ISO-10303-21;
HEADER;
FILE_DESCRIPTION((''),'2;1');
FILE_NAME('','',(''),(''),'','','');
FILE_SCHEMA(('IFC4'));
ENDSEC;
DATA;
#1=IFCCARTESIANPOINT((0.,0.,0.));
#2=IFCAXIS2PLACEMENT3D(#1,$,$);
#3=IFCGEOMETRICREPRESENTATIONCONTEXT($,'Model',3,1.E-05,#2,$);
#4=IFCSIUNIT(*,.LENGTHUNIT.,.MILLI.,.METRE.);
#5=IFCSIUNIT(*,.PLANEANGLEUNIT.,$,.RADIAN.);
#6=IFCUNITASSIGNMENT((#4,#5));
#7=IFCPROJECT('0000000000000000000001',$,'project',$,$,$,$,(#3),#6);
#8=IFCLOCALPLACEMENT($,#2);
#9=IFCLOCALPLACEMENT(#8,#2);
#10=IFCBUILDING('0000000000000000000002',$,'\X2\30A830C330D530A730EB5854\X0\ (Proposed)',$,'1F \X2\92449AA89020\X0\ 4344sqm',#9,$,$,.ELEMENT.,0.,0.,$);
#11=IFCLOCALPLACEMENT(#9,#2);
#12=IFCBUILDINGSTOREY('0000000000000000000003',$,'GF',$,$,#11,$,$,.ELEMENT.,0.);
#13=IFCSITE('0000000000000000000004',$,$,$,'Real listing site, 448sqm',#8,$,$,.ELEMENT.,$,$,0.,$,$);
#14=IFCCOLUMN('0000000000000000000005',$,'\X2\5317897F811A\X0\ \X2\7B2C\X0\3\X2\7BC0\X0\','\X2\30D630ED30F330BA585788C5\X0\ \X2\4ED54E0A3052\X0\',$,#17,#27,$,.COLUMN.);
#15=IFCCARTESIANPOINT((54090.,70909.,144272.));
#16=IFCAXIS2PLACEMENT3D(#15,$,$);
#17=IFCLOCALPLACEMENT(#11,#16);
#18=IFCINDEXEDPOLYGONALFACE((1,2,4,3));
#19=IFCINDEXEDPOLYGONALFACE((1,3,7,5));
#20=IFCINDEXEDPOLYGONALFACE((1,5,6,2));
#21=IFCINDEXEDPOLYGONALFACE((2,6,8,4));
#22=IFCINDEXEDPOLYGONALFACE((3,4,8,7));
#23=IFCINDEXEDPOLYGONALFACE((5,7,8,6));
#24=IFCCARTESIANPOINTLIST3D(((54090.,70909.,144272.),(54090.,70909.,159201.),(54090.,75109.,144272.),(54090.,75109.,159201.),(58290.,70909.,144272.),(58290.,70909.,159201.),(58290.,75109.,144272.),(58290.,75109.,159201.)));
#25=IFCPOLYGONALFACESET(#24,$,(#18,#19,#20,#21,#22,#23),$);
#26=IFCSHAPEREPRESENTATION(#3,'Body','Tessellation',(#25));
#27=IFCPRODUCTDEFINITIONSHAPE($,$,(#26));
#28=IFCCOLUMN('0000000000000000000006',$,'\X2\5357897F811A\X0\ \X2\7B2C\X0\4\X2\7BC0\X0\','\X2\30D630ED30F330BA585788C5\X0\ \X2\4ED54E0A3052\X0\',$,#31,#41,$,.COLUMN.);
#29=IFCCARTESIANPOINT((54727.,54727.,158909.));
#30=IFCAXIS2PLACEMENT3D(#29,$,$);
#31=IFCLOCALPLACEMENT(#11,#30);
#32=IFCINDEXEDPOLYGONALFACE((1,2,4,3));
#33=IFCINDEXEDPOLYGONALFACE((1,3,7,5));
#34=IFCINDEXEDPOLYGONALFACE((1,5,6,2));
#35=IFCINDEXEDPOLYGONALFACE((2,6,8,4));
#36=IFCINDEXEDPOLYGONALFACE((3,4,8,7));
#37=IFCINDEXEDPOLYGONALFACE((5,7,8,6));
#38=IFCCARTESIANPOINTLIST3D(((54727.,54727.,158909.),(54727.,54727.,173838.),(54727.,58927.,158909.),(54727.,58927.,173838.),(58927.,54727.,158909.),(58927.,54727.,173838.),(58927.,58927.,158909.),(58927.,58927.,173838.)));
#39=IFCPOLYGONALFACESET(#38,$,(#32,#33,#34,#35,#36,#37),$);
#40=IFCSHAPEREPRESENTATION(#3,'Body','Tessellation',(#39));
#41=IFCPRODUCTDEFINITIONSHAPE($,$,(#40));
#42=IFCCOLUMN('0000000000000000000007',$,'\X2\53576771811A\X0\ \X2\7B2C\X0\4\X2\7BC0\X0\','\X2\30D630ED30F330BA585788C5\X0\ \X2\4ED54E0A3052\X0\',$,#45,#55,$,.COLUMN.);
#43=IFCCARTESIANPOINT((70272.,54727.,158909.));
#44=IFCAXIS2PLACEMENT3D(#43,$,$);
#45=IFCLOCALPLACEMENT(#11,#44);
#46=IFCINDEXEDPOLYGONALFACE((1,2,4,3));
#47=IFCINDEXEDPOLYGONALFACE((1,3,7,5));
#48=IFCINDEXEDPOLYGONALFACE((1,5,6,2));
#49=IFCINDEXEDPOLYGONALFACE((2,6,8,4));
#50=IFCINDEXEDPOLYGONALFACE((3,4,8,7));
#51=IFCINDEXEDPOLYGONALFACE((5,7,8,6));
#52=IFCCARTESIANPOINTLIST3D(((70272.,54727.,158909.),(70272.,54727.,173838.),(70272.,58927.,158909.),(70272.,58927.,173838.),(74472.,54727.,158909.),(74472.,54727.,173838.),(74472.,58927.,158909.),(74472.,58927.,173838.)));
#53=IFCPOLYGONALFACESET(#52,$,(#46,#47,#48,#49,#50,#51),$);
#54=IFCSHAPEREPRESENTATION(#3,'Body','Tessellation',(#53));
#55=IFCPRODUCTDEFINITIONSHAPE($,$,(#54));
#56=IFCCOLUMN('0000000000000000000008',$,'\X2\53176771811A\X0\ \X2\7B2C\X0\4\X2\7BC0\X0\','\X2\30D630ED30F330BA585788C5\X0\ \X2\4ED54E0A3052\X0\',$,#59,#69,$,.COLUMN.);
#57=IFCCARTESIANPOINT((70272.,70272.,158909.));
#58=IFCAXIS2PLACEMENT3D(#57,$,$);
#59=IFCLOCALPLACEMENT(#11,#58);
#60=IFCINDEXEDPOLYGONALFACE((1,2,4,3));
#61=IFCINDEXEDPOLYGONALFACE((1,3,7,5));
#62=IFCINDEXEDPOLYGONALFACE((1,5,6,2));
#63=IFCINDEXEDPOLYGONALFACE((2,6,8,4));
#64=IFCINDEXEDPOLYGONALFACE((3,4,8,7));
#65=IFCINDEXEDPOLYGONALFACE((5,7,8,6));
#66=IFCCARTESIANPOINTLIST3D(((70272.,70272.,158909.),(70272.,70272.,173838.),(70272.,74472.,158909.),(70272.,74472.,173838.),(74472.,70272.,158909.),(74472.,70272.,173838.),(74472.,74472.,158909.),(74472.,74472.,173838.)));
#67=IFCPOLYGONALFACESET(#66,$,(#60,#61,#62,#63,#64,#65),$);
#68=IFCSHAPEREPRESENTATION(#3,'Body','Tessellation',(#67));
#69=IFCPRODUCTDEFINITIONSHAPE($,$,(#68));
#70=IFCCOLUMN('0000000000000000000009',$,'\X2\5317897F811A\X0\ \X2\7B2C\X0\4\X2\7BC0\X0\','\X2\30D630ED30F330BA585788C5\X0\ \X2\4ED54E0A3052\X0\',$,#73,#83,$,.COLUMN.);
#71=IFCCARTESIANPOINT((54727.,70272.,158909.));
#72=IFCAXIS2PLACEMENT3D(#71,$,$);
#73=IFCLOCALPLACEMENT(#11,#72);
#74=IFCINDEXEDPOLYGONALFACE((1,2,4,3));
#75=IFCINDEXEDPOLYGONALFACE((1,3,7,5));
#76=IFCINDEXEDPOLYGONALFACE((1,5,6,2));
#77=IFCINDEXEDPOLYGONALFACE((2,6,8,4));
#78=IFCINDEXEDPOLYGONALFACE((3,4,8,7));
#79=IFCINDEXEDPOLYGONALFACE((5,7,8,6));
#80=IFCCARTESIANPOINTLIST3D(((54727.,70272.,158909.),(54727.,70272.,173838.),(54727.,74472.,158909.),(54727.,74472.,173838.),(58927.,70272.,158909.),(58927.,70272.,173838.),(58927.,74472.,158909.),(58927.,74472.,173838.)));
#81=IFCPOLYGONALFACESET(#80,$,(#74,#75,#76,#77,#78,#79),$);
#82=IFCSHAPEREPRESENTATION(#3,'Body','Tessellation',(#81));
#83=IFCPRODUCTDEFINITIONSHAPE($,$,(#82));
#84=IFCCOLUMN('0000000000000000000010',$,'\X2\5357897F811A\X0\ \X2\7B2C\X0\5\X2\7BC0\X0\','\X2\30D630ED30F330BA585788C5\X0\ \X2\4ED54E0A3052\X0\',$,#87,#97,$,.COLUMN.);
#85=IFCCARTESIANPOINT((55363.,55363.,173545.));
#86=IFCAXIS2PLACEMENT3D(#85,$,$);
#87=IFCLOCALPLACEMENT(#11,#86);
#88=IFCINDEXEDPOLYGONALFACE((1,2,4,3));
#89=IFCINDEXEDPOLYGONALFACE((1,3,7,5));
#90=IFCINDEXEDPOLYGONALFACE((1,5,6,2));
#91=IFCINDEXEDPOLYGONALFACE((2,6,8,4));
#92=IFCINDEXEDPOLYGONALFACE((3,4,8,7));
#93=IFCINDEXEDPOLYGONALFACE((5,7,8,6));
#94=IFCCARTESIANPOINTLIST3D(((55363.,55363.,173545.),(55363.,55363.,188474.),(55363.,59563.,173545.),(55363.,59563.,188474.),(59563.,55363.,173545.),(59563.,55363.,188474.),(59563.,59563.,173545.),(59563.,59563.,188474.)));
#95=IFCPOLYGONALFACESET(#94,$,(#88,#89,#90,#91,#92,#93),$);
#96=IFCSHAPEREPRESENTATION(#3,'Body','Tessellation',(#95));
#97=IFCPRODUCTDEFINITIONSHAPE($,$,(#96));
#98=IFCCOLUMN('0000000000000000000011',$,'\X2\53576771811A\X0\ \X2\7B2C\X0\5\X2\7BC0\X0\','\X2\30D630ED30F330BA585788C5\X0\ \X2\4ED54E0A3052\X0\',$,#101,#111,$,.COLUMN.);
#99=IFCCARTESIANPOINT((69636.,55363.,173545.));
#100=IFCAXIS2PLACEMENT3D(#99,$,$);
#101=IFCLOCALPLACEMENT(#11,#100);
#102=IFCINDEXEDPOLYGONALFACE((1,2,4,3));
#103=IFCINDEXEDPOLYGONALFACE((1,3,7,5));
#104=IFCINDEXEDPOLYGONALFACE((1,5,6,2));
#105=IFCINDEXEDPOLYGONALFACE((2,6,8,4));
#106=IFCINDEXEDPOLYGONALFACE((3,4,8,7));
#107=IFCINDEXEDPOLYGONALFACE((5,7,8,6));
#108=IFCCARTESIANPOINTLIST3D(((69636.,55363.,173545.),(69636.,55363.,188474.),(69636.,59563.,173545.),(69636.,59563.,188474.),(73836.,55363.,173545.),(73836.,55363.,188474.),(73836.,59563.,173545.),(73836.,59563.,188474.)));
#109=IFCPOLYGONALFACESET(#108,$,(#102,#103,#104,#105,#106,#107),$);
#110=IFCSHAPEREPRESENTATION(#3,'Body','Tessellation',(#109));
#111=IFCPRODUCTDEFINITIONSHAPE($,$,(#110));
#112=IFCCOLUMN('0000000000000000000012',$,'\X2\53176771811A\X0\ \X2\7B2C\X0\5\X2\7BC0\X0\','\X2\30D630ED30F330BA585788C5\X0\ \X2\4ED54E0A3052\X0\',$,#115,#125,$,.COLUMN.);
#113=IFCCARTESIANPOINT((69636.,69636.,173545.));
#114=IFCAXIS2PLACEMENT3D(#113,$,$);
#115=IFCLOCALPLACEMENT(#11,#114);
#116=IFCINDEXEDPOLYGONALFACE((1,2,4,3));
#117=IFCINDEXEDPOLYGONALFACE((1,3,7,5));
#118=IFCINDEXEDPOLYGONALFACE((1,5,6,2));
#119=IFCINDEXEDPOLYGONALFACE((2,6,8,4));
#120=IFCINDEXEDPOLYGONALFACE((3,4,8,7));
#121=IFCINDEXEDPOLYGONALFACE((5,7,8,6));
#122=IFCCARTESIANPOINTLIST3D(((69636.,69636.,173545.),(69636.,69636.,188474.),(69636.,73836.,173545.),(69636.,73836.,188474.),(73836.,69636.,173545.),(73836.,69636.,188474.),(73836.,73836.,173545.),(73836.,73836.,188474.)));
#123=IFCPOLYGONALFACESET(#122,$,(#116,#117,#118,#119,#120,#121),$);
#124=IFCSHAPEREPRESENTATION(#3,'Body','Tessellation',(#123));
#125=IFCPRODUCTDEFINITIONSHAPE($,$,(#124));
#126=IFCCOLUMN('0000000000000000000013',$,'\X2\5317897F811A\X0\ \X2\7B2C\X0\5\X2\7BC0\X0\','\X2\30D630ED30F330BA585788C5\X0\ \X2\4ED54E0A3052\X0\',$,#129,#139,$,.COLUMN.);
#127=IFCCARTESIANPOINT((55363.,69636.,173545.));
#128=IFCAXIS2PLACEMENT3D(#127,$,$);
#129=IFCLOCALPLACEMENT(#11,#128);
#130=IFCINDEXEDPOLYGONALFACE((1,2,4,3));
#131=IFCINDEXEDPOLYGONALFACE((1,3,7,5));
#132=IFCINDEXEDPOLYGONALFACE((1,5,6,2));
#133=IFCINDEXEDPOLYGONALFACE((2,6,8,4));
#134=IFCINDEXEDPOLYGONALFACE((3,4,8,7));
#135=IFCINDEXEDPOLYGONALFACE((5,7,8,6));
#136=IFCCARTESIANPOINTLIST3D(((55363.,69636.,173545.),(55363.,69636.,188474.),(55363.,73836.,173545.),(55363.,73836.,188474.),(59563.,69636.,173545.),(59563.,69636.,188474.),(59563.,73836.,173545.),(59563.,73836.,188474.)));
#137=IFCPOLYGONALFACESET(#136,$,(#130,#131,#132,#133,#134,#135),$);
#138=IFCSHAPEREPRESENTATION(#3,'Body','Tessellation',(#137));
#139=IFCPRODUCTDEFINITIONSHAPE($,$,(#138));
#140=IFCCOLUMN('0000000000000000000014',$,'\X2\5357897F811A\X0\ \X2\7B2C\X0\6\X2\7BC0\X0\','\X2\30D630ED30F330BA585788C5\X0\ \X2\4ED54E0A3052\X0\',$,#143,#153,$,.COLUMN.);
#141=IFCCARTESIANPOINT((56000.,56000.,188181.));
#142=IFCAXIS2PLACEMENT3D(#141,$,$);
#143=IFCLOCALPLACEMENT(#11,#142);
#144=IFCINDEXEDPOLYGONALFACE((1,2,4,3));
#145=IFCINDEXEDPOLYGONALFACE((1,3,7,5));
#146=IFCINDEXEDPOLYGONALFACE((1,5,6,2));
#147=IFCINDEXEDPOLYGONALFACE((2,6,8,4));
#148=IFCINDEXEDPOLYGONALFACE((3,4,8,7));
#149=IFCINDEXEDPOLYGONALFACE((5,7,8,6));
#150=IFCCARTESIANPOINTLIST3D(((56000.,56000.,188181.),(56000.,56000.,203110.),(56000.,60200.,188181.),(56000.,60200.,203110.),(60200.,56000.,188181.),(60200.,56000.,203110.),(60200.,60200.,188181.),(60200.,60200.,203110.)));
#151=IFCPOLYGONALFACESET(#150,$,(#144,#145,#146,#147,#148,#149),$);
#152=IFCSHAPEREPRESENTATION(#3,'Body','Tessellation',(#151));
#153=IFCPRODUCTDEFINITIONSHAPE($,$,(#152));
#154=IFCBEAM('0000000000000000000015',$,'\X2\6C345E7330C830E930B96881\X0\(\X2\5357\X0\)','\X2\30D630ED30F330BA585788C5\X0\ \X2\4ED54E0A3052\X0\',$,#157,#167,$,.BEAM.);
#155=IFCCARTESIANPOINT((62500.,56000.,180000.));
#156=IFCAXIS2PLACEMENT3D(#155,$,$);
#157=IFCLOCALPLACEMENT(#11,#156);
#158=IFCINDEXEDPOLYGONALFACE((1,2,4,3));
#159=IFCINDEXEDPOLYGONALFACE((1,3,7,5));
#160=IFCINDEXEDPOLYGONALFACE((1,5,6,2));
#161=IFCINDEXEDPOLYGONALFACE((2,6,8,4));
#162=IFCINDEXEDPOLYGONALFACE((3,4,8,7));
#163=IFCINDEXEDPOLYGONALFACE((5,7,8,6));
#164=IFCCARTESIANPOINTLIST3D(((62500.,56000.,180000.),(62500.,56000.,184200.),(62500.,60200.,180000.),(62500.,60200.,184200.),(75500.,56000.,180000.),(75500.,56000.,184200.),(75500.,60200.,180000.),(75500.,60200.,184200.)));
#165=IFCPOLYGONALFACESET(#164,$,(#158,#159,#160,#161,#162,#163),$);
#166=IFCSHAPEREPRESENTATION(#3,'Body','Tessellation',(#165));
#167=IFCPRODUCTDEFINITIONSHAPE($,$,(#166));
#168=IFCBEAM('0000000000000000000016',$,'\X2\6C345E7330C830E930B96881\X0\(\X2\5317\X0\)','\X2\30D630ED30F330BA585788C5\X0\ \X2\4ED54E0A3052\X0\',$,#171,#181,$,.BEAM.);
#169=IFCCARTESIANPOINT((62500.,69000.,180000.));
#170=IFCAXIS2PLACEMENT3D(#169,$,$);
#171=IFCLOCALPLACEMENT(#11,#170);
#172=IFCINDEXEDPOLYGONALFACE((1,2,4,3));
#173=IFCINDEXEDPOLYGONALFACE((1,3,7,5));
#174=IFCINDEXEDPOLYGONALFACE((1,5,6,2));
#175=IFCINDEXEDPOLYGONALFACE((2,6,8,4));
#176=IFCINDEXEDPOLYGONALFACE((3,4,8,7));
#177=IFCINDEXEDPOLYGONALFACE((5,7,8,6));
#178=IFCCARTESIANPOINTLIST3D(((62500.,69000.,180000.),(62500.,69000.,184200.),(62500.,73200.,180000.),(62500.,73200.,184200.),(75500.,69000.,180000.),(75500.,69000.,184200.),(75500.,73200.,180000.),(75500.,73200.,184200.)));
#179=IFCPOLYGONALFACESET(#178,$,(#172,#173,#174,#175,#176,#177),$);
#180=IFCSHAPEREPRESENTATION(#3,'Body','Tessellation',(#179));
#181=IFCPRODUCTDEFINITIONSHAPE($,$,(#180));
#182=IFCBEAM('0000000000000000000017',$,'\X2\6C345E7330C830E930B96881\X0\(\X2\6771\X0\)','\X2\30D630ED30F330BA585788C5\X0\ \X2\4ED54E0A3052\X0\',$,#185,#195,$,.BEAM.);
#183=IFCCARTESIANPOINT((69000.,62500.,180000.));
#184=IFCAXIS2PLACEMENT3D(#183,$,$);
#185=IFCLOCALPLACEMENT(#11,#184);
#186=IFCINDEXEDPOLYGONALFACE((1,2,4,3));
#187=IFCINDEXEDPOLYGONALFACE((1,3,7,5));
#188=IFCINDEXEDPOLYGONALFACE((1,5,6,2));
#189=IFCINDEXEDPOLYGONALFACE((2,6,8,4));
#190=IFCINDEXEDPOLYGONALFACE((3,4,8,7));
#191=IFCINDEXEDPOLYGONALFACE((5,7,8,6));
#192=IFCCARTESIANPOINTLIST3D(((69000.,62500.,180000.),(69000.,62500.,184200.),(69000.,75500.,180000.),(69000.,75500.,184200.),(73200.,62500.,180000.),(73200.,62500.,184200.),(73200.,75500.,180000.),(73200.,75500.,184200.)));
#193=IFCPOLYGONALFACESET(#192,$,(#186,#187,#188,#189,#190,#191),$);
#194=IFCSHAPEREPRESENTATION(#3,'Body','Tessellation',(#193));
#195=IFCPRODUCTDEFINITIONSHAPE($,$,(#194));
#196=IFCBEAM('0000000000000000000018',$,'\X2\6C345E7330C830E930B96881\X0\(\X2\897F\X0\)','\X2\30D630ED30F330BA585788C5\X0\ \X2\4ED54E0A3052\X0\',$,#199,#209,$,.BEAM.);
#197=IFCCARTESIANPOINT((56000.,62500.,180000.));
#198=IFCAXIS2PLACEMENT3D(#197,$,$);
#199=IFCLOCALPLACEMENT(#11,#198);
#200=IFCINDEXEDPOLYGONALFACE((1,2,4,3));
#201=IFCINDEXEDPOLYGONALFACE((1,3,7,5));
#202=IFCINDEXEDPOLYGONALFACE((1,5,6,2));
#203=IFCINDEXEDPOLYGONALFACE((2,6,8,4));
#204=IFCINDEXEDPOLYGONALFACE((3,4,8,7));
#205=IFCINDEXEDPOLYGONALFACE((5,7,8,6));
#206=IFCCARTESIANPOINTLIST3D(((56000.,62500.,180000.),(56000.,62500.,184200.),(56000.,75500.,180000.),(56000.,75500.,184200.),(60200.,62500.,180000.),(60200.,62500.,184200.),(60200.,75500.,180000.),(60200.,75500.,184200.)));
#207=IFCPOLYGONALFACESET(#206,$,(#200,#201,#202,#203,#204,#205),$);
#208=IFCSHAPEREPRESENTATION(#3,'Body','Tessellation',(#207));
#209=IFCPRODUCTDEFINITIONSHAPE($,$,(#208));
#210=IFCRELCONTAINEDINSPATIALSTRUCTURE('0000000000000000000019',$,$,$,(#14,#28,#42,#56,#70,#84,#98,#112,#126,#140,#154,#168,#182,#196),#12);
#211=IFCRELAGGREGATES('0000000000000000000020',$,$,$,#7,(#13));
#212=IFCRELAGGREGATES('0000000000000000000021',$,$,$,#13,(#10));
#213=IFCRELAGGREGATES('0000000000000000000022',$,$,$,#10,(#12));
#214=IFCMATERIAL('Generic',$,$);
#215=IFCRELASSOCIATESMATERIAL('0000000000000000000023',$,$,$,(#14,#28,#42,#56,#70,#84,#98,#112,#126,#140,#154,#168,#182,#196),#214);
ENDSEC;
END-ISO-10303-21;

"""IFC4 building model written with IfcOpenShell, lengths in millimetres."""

from ifc_helpers import new_model, si_unit, frame, frame_2d, origin, place, context, project, spatial, rectangle, extrude, material, element, save


model = new_model("IFC4")

# Units and contexts
model_context = context("Model", 3, precision=1e-05, world=origin())
ifc_project = project(units=[si_unit("LENGTHUNIT", "METRE", prefix="MILLI"), si_unit("PLANEANGLEUNIT", "RADIAN")], contexts=[model_context])

# Site, building, storey
site_placement = place(None, origin())
site = spatial("IfcSite", under=ifc_project, at=site_placement, ObjectType="Real listing site, 448sqm", CompositionType="ELEMENT", RefElevation=0.0)
building_placement = place(site_placement, origin())
building = spatial("IfcBuilding", under=site, at=building_placement, Name="エッフェル塔 (Proposed)", ObjectType="1F 鉄骨造 4344sqm", CompositionType="ELEMENT", ElevationOfRefHeight=0.0, ElevationOfTerrain=0.0)
storey_placement = place(building_placement, origin())
storey = spatial("IfcBuildingStorey", under=building, at=storey_placement, Name="GF", CompositionType="ELEMENT", Elevation=0.0)

# Columns
ifc_material = material(Name="Generic")
column_1_placement = place(storey_placement, frame((54090.0, 70909.0, 144272.0)))
element("IfcColumn", 1, at=column_1_placement, inside=storey, material=ifc_material, Name="北西脚 第3節", Description="ブロンズ塗装 仕上げ", PredefinedType="COLUMN", context=model_context, shape_type="SweptSolid", body=[
    extrude(rectangle(XDim=4200.0, YDim=4200.0, at=frame_2d((2100.0, 2100.0))), frame((54090.0, 70909.0, 144272.0)), (0.0, 0.0, 1.0), 14929.0),
])
column_2_placement = place(storey_placement, frame((54727.0, 54727.0, 158909.0)))
element("IfcColumn", 2, at=column_2_placement, inside=storey, material=ifc_material, Name="南西脚 第4節", Description="ブロンズ塗装 仕上げ", PredefinedType="COLUMN", context=model_context, shape_type="SweptSolid", body=[
    extrude(rectangle(XDim=4200.0, YDim=4200.0, at=frame_2d((2100.0, 2100.0))), frame((54727.0, 54727.0, 158909.0)), (0.0, 0.0, 1.0), 14929.0),
])
column_3_placement = place(storey_placement, frame((70272.0, 54727.0, 158909.0)))
element("IfcColumn", 3, at=column_3_placement, inside=storey, material=ifc_material, Name="南東脚 第4節", Description="ブロンズ塗装 仕上げ", PredefinedType="COLUMN", context=model_context, shape_type="SweptSolid", body=[
    extrude(rectangle(XDim=4200.0, YDim=4200.0, at=frame_2d((2100.0, 2100.0))), frame((70272.0, 54727.0, 158909.0)), (0.0, 0.0, 1.0), 14929.0),
])
column_4_placement = place(storey_placement, frame((70272.0, 70272.0, 158909.0)))
element("IfcColumn", 4, at=column_4_placement, inside=storey, material=ifc_material, Name="北東脚 第4節", Description="ブロンズ塗装 仕上げ", PredefinedType="COLUMN", context=model_context, shape_type="SweptSolid", body=[
    extrude(rectangle(XDim=4200.0, YDim=4200.0, at=frame_2d((2100.0, 2100.0))), frame((70272.0, 70272.0, 158909.0)), (0.0, 0.0, 1.0), 14929.0),
])
column_5_placement = place(storey_placement, frame((54727.0, 70272.0, 158909.0)))
element("IfcColumn", 5, at=column_5_placement, inside=storey, material=ifc_material, Name="北西脚 第4節", Description="ブロンズ塗装 仕上げ", PredefinedType="COLUMN", context=model_context, shape_type="SweptSolid", body=[
    extrude(rectangle(XDim=4200.0, YDim=4200.0, at=frame_2d((2100.0, 2100.0))), frame((54727.0, 70272.0, 158909.0)), (0.0, 0.0, 1.0), 14929.0),
])
column_6_placement = place(storey_placement, frame((55363.0, 55363.0, 173545.0)))
element("IfcColumn", 6, at=column_6_placement, inside=storey, material=ifc_material, Name="南西脚 第5節", Description="ブロンズ塗装 仕上げ", PredefinedType="COLUMN", context=model_context, shape_type="SweptSolid", body=[
    extrude(rectangle(XDim=4200.0, YDim=4200.0, at=frame_2d((2100.0, 2100.0))), frame((55363.0, 55363.0, 173545.0)), (0.0, 0.0, 1.0), 14929.0),
])
column_7_placement = place(storey_placement, frame((69636.0, 55363.0, 173545.0)))
element("IfcColumn", 7, at=column_7_placement, inside=storey, material=ifc_material, Name="南東脚 第5節", Description="ブロンズ塗装 仕上げ", PredefinedType="COLUMN", context=model_context, shape_type="SweptSolid", body=[
    extrude(rectangle(XDim=4200.0, YDim=4200.0, at=frame_2d((2100.0, 2100.0))), frame((69636.0, 55363.0, 173545.0)), (0.0, 0.0, 1.0), 14929.0),
])
column_8_placement = place(storey_placement, frame((69636.0, 69636.0, 173545.0)))
element("IfcColumn", 8, at=column_8_placement, inside=storey, material=ifc_material, Name="北東脚 第5節", Description="ブロンズ塗装 仕上げ", PredefinedType="COLUMN", context=model_context, shape_type="SweptSolid", body=[
    extrude(rectangle(XDim=4200.0, YDim=4200.0, at=frame_2d((2100.0, 2100.0))), frame((69636.0, 69636.0, 173545.0)), (0.0, 0.0, 1.0), 14929.0),
])
column_9_placement = place(storey_placement, frame((55363.0, 69636.0, 173545.0)))
element("IfcColumn", 9, at=column_9_placement, inside=storey, material=ifc_material, Name="北西脚 第5節", Description="ブロンズ塗装 仕上げ", PredefinedType="COLUMN", context=model_context, shape_type="SweptSolid", body=[
    extrude(rectangle(XDim=4200.0, YDim=4200.0, at=frame_2d((2100.0, 2100.0))), frame((55363.0, 69636.0, 173545.0)), (0.0, 0.0, 1.0), 14929.0),
])
column_10_placement = place(storey_placement, frame((56000.0, 56000.0, 188181.0)))
element("IfcColumn", 10, at=column_10_placement, inside=storey, material=ifc_material, Name="南西脚 第6節", Description="ブロンズ塗装 仕上げ", PredefinedType="COLUMN", context=model_context, shape_type="SweptSolid", body=[
    extrude(rectangle(XDim=4200.0, YDim=4200.0, at=frame_2d((2100.0, 2100.0))), frame((56000.0, 56000.0, 188181.0)), (0.0, 0.0, 1.0), 14929.0),
])

# Beams
beam_1_placement = place(storey_placement, frame((62500.0, 56000.0, 180000.0)))
element("IfcBeam", 11, at=beam_1_placement, inside=storey, material=ifc_material, Name="水平トラス梁(南)", Description="ブロンズ塗装 仕上げ", PredefinedType="BEAM", context=model_context, shape_type="SweptSolid", body=[
    extrude(rectangle(XDim=13000.0, YDim=4200.0, at=frame_2d((6500.0, 2100.0))), frame((62500.0, 56000.0, 180000.0)), (0.0, 0.0, 1.0), 4200.0),
])
beam_2_placement = place(storey_placement, frame((62500.0, 69000.0, 180000.0)))
element("IfcBeam", 12, at=beam_2_placement, inside=storey, material=ifc_material, Name="水平トラス梁(北)", Description="ブロンズ塗装 仕上げ", PredefinedType="BEAM", context=model_context, shape_type="SweptSolid", body=[
    extrude(rectangle(XDim=13000.0, YDim=4200.0, at=frame_2d((6500.0, 2100.0))), frame((62500.0, 69000.0, 180000.0)), (0.0, 0.0, 1.0), 4200.0),
])
beam_3_placement = place(storey_placement, frame((69000.0, 62500.0, 180000.0)))
element("IfcBeam", 13, at=beam_3_placement, inside=storey, material=ifc_material, Name="水平トラス梁(東)", Description="ブロンズ塗装 仕上げ", PredefinedType="BEAM", context=model_context, shape_type="SweptSolid", body=[
    extrude(rectangle(XDim=4200.0, YDim=13000.0, at=frame_2d((2100.0, 6500.0))), frame((69000.0, 62500.0, 180000.0)), (0.0, 0.0, 1.0), 4200.0),
])
beam_4_placement = place(storey_placement, frame((56000.0, 62500.0, 180000.0)))
element("IfcBeam", 14, at=beam_4_placement, inside=storey, material=ifc_material, Name="水平トラス梁(西)", Description="ブロンズ塗装 仕上げ", PredefinedType="BEAM", context=model_context, shape_type="SweptSolid", body=[
    extrude(rectangle(XDim=4200.0, YDim=13000.0, at=frame_2d((2100.0, 6500.0))), frame((56000.0, 62500.0, 180000.0)), (0.0, 0.0, 1.0), 4200.0),
])

save(model, "model.ifc")
